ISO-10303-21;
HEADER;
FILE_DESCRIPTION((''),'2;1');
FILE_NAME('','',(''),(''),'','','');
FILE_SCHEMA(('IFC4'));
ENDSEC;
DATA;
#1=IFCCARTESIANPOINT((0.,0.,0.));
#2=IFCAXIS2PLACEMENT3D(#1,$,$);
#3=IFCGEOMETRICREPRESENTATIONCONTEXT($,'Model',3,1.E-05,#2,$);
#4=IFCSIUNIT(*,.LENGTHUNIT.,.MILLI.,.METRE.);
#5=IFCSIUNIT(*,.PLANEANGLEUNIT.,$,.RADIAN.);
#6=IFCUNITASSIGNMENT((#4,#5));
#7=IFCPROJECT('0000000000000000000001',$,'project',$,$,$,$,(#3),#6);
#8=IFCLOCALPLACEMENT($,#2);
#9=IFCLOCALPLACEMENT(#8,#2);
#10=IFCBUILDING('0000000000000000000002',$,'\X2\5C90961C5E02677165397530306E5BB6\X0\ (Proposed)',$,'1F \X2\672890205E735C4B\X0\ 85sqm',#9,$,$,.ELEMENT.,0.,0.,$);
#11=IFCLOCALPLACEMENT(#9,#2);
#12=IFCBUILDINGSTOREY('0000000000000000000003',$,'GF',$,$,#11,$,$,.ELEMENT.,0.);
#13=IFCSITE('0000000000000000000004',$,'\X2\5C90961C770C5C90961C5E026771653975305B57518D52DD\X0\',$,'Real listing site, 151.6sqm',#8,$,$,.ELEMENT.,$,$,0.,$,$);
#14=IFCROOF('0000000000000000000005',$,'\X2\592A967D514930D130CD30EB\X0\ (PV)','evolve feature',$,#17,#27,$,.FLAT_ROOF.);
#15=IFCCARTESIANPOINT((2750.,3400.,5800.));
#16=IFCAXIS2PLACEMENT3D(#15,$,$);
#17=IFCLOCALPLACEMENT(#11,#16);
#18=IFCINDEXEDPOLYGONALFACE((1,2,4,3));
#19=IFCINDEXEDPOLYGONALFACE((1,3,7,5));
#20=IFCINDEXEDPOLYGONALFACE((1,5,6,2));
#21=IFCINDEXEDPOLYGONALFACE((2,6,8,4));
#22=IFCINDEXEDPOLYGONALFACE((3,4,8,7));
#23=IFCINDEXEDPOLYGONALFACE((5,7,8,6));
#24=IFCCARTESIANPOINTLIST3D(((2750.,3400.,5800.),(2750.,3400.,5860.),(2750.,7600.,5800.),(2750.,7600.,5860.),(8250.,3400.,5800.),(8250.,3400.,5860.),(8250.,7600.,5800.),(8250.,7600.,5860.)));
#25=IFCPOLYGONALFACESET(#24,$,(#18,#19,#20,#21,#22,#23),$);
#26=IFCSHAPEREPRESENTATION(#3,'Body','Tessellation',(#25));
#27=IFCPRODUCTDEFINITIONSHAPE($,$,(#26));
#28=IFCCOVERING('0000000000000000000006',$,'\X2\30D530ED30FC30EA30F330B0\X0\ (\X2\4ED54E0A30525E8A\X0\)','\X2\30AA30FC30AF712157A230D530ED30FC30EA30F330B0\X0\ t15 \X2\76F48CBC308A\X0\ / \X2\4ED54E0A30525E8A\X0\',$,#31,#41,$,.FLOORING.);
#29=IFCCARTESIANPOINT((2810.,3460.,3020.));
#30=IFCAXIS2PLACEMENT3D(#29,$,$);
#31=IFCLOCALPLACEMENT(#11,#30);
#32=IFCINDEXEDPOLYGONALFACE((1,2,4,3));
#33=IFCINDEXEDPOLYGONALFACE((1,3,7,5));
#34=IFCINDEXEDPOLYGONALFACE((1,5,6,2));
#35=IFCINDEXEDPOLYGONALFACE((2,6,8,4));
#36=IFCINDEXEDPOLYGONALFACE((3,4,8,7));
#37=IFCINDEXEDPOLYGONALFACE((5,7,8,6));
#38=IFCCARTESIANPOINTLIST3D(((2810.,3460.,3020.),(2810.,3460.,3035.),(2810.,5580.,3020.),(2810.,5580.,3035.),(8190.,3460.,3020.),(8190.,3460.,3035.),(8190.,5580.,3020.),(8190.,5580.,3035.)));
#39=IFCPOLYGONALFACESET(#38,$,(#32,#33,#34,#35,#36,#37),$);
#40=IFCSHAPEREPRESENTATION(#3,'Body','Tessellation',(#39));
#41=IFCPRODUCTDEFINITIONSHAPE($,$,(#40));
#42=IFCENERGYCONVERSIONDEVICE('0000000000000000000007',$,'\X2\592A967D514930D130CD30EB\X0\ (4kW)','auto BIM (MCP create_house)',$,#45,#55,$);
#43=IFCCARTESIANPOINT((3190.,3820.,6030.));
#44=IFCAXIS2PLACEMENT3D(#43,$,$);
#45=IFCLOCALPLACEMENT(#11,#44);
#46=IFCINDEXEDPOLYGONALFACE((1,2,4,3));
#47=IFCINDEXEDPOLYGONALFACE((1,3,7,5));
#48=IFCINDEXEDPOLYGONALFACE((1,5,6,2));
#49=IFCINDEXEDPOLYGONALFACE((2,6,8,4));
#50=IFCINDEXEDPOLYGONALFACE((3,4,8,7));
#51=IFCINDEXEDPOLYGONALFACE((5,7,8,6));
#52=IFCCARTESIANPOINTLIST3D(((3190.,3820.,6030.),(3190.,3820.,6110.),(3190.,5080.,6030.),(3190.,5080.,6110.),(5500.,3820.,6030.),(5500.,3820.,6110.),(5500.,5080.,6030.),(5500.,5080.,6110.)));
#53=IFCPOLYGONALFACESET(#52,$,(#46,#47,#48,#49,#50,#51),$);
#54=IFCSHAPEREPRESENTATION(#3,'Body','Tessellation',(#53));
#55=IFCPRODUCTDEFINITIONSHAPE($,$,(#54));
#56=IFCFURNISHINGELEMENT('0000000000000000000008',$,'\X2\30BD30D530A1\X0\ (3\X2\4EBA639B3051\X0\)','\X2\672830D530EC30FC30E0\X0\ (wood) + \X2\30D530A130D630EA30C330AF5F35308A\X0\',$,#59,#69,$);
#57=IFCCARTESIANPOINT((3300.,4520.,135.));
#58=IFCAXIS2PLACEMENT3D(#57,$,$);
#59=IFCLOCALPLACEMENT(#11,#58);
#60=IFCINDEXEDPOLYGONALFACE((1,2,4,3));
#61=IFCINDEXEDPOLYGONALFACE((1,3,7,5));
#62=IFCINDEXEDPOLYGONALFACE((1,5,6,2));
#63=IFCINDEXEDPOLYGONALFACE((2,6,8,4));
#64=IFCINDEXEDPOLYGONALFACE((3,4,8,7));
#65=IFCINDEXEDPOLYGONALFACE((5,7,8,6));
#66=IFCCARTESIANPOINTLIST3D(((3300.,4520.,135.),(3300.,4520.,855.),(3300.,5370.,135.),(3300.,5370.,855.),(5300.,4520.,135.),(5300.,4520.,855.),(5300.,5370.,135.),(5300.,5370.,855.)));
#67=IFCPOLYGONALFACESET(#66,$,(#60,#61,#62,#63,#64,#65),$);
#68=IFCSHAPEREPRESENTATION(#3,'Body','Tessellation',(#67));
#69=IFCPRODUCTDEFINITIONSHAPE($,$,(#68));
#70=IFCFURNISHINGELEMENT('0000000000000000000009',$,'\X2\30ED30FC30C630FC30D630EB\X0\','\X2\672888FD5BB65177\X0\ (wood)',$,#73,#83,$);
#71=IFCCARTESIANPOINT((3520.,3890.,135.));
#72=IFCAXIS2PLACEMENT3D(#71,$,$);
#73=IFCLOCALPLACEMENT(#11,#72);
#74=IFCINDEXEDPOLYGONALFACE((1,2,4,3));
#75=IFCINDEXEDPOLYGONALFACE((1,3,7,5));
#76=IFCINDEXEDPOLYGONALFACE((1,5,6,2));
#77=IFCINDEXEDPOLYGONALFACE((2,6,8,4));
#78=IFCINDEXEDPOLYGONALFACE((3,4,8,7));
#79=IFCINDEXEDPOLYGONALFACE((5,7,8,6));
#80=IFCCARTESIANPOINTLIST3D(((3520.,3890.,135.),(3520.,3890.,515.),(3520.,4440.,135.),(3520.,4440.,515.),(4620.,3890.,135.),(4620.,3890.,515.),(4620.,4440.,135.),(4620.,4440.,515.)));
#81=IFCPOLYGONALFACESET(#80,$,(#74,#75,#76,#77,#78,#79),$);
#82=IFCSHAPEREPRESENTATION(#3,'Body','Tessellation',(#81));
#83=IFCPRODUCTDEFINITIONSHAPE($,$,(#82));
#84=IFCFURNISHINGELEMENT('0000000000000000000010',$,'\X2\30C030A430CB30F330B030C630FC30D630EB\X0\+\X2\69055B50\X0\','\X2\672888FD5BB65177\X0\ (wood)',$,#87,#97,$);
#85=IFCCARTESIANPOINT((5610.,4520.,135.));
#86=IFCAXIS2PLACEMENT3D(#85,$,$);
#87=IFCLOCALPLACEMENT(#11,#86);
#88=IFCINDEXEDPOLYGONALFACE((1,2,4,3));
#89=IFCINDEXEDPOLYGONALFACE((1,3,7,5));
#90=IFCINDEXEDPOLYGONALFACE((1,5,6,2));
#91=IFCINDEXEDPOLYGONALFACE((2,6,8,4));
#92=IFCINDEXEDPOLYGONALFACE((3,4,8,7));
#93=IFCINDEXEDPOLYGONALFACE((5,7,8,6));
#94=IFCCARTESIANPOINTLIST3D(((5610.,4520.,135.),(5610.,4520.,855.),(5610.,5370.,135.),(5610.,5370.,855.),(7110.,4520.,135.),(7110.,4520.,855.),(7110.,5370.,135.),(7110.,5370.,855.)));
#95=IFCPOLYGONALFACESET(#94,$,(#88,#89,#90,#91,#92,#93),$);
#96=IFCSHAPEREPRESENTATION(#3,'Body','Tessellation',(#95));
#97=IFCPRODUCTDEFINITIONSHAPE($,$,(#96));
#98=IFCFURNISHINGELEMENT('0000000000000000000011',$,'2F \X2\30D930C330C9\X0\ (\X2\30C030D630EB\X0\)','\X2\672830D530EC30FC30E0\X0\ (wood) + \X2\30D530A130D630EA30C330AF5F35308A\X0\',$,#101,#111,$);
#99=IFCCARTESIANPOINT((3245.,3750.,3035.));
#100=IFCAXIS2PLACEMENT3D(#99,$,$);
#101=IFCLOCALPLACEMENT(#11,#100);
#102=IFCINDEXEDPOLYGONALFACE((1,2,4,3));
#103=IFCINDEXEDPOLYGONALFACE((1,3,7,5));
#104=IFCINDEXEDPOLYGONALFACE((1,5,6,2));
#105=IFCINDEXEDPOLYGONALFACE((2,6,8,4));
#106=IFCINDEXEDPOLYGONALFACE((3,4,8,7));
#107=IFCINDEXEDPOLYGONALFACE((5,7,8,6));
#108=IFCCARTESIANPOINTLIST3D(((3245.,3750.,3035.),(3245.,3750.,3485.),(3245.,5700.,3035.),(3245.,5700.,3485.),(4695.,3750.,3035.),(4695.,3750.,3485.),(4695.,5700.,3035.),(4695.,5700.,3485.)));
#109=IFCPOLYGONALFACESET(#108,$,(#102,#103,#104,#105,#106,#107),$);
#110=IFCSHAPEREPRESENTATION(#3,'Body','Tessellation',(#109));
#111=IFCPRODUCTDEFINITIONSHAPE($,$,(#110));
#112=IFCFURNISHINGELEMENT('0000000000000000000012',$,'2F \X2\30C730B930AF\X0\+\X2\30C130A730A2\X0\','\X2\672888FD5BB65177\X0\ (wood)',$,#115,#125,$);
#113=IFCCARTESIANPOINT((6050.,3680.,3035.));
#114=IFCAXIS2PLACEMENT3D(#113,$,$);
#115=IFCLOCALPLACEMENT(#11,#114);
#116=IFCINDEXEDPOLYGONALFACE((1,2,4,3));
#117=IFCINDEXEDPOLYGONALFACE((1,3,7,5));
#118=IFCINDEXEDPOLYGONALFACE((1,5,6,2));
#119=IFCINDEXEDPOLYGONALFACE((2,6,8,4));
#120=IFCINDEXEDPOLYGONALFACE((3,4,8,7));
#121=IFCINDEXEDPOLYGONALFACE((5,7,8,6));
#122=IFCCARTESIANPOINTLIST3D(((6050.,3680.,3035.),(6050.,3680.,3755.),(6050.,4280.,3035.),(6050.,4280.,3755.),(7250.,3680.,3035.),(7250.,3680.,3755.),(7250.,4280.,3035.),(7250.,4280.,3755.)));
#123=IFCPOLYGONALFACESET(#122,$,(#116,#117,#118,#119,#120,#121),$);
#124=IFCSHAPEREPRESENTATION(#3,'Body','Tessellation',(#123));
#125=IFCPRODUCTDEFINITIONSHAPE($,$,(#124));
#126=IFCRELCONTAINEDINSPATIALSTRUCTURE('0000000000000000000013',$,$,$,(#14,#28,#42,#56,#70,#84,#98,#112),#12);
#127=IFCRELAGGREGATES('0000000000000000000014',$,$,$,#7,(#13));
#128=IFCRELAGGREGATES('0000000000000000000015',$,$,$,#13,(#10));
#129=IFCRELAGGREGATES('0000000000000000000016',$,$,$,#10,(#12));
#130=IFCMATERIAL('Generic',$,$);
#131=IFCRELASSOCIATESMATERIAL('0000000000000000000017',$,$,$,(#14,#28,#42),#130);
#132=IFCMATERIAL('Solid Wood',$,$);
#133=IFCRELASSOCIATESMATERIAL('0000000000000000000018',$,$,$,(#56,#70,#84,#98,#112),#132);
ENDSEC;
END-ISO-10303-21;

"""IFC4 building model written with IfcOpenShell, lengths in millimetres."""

from ifc_helpers import new_model, si_unit, frame, frame_2d, origin, place, context, project, spatial, rectangle, extrude, material, element, save


model = new_model("IFC4")

# Units and contexts
model_context = context("Model", 3, precision=1e-05, world=origin())
ifc_project = project(units=[si_unit("LENGTHUNIT", "METRE", prefix="MILLI"), si_unit("PLANEANGLEUNIT", "RADIAN")], contexts=[model_context])

# Site, building, storey
site_placement = place(None, origin())
site = spatial("IfcSite", under=ifc_project, at=site_placement, Name="岐阜県岐阜市東改田字再勝", ObjectType="Real listing site, 151.6sqm", CompositionType="ELEMENT", RefElevation=0.0)
building_placement = place(site_placement, origin())
building = spatial("IfcBuilding", under=site, at=building_placement, Name="岐阜市東改田の家 (Proposed)", ObjectType="1F 木造平屋 85sqm", CompositionType="ELEMENT", ElevationOfRefHeight=0.0, ElevationOfTerrain=0.0)
storey_placement = place(building_placement, origin())
storey = spatial("IfcBuildingStorey", under=building, at=storey_placement, Name="GF", CompositionType="ELEMENT", Elevation=0.0)

# Shared definitions
ifc_material_1 = material(Name="Solid Wood")

# Roof
ifc_material_2 = material(Name="Generic")
roof_1_placement = place(storey_placement, frame((2750.0, 3400.0, 5800.0)))
element("IfcRoof", 1, at=roof_1_placement, inside=storey, material=ifc_material_2, Name="太陽光パネル (PV)", Description="evolve feature", PredefinedType="FLAT_ROOF", context=model_context, shape_type="SweptSolid", body=[
    extrude(rectangle(XDim=5500.0, YDim=4200.0, at=frame_2d((2750.0, 2100.0))), frame((2750.0, 3400.0, 5800.0)), (0.0, 0.0, 1.0), 60.0),
])

# Covering
covering_placement = place(storey_placement, frame((2810.0, 3460.0, 3020.0)))
element("IfcCovering", 2, at=covering_placement, inside=storey, material=ifc_material_2, Name="フローリング (仕上げ床)", Description="オーク無垢フローリング t15 直貼り / 仕上げ床", PredefinedType="FLOORING", context=model_context, shape_type="SweptSolid", body=[
    extrude(rectangle(XDim=5380.0, YDim=2120.0, at=frame_2d((2690.0, 1060.0))), frame((2810.0, 3460.0, 3020.0)), (0.0, 0.0, 1.0), 15.0),
])

# Energy conversion device
energy_conversion_device_placement = place(storey_placement, frame((3190.0, 3820.0, 6030.0)))
element("IfcEnergyConversionDevice", 3, at=energy_conversion_device_placement, inside=storey, material=ifc_material_2, Name="太陽光パネル (4kW)", Description="auto BIM (MCP create_house)", context=model_context, shape_type="SweptSolid", body=[
    extrude(rectangle(XDim=2310.0, YDim=1260.0, at=frame_2d((1155.0, 630.0))), frame((3190.0, 3820.0, 6030.0)), (0.0, 0.0, 1.0), 80.0),
])

# Furnishing elements
furnishing_1_placement = place(storey_placement, frame((3300.0, 4520.0, 135.0)))
element("IfcFurnishingElement", 4, at=furnishing_1_placement, inside=storey, material=ifc_material_1, Name="ソファ (3人掛け)", Description="木フレーム (wood) + ファブリック張り", context=model_context, shape_type="SweptSolid", body=[
    extrude(rectangle(XDim=2000.0, YDim=850.0, at=frame_2d((1000.0, 425.0))), frame((3300.0, 4520.0, 135.0)), (0.0, 0.0, 1.0), 720.0),
])
furnishing_2_placement = place(storey_placement, frame((3520.0, 3890.0, 135.0)))
element("IfcFurnishingElement", 5, at=furnishing_2_placement, inside=storey, material=ifc_material_1, Name="ローテーブル", Description="木製家具 (wood)", context=model_context, shape_type="SweptSolid", body=[
    extrude(rectangle(XDim=1100.0, YDim=550.0, at=frame_2d((550.0, 275.0))), frame((3520.0, 3890.0, 135.0)), (0.0, 0.0, 1.0), 380.0),
])
furnishing_3_placement = place(storey_placement, frame((5610.0, 4520.0, 135.0)))
element("IfcFurnishingElement", 6, at=furnishing_3_placement, inside=storey, material=ifc_material_1, Name="ダイニングテーブル+椅子", Description="木製家具 (wood)", context=model_context, shape_type="SweptSolid", body=[
    extrude(rectangle(XDim=1500.0, YDim=850.0, at=frame_2d((750.0, 425.0))), frame((5610.0, 4520.0, 135.0)), (0.0, 0.0, 1.0), 720.0),
])
furnishing_4_placement = place(storey_placement, frame((3245.0, 3750.0, 3035.0)))
element("IfcFurnishingElement", 7, at=furnishing_4_placement, inside=storey, material=ifc_material_1, Name="2F ベッド (ダブル)", Description="木フレーム (wood) + ファブリック張り", context=model_context, shape_type="SweptSolid", body=[
    extrude(rectangle(XDim=1450.0, YDim=1950.0, at=frame_2d((725.0, 975.0))), frame((3245.0, 3750.0, 3035.0)), (0.0, 0.0, 1.0), 450.0),
])
furnishing_5_placement = place(storey_placement, frame((6050.0, 3680.0, 3035.0)))
element("IfcFurnishingElement", 8, at=furnishing_5_placement, inside=storey, material=ifc_material_1, Name="2F デスク+チェア", Description="木製家具 (wood)", context=model_context, shape_type="SweptSolid", body=[
    extrude(rectangle(XDim=1200.0, YDim=600.0, at=frame_2d((600.0, 300.0))), frame((6050.0, 3680.0, 3035.0)), (0.0, 0.0, 1.0), 720.0),
])

save(model, "model.ifc")
